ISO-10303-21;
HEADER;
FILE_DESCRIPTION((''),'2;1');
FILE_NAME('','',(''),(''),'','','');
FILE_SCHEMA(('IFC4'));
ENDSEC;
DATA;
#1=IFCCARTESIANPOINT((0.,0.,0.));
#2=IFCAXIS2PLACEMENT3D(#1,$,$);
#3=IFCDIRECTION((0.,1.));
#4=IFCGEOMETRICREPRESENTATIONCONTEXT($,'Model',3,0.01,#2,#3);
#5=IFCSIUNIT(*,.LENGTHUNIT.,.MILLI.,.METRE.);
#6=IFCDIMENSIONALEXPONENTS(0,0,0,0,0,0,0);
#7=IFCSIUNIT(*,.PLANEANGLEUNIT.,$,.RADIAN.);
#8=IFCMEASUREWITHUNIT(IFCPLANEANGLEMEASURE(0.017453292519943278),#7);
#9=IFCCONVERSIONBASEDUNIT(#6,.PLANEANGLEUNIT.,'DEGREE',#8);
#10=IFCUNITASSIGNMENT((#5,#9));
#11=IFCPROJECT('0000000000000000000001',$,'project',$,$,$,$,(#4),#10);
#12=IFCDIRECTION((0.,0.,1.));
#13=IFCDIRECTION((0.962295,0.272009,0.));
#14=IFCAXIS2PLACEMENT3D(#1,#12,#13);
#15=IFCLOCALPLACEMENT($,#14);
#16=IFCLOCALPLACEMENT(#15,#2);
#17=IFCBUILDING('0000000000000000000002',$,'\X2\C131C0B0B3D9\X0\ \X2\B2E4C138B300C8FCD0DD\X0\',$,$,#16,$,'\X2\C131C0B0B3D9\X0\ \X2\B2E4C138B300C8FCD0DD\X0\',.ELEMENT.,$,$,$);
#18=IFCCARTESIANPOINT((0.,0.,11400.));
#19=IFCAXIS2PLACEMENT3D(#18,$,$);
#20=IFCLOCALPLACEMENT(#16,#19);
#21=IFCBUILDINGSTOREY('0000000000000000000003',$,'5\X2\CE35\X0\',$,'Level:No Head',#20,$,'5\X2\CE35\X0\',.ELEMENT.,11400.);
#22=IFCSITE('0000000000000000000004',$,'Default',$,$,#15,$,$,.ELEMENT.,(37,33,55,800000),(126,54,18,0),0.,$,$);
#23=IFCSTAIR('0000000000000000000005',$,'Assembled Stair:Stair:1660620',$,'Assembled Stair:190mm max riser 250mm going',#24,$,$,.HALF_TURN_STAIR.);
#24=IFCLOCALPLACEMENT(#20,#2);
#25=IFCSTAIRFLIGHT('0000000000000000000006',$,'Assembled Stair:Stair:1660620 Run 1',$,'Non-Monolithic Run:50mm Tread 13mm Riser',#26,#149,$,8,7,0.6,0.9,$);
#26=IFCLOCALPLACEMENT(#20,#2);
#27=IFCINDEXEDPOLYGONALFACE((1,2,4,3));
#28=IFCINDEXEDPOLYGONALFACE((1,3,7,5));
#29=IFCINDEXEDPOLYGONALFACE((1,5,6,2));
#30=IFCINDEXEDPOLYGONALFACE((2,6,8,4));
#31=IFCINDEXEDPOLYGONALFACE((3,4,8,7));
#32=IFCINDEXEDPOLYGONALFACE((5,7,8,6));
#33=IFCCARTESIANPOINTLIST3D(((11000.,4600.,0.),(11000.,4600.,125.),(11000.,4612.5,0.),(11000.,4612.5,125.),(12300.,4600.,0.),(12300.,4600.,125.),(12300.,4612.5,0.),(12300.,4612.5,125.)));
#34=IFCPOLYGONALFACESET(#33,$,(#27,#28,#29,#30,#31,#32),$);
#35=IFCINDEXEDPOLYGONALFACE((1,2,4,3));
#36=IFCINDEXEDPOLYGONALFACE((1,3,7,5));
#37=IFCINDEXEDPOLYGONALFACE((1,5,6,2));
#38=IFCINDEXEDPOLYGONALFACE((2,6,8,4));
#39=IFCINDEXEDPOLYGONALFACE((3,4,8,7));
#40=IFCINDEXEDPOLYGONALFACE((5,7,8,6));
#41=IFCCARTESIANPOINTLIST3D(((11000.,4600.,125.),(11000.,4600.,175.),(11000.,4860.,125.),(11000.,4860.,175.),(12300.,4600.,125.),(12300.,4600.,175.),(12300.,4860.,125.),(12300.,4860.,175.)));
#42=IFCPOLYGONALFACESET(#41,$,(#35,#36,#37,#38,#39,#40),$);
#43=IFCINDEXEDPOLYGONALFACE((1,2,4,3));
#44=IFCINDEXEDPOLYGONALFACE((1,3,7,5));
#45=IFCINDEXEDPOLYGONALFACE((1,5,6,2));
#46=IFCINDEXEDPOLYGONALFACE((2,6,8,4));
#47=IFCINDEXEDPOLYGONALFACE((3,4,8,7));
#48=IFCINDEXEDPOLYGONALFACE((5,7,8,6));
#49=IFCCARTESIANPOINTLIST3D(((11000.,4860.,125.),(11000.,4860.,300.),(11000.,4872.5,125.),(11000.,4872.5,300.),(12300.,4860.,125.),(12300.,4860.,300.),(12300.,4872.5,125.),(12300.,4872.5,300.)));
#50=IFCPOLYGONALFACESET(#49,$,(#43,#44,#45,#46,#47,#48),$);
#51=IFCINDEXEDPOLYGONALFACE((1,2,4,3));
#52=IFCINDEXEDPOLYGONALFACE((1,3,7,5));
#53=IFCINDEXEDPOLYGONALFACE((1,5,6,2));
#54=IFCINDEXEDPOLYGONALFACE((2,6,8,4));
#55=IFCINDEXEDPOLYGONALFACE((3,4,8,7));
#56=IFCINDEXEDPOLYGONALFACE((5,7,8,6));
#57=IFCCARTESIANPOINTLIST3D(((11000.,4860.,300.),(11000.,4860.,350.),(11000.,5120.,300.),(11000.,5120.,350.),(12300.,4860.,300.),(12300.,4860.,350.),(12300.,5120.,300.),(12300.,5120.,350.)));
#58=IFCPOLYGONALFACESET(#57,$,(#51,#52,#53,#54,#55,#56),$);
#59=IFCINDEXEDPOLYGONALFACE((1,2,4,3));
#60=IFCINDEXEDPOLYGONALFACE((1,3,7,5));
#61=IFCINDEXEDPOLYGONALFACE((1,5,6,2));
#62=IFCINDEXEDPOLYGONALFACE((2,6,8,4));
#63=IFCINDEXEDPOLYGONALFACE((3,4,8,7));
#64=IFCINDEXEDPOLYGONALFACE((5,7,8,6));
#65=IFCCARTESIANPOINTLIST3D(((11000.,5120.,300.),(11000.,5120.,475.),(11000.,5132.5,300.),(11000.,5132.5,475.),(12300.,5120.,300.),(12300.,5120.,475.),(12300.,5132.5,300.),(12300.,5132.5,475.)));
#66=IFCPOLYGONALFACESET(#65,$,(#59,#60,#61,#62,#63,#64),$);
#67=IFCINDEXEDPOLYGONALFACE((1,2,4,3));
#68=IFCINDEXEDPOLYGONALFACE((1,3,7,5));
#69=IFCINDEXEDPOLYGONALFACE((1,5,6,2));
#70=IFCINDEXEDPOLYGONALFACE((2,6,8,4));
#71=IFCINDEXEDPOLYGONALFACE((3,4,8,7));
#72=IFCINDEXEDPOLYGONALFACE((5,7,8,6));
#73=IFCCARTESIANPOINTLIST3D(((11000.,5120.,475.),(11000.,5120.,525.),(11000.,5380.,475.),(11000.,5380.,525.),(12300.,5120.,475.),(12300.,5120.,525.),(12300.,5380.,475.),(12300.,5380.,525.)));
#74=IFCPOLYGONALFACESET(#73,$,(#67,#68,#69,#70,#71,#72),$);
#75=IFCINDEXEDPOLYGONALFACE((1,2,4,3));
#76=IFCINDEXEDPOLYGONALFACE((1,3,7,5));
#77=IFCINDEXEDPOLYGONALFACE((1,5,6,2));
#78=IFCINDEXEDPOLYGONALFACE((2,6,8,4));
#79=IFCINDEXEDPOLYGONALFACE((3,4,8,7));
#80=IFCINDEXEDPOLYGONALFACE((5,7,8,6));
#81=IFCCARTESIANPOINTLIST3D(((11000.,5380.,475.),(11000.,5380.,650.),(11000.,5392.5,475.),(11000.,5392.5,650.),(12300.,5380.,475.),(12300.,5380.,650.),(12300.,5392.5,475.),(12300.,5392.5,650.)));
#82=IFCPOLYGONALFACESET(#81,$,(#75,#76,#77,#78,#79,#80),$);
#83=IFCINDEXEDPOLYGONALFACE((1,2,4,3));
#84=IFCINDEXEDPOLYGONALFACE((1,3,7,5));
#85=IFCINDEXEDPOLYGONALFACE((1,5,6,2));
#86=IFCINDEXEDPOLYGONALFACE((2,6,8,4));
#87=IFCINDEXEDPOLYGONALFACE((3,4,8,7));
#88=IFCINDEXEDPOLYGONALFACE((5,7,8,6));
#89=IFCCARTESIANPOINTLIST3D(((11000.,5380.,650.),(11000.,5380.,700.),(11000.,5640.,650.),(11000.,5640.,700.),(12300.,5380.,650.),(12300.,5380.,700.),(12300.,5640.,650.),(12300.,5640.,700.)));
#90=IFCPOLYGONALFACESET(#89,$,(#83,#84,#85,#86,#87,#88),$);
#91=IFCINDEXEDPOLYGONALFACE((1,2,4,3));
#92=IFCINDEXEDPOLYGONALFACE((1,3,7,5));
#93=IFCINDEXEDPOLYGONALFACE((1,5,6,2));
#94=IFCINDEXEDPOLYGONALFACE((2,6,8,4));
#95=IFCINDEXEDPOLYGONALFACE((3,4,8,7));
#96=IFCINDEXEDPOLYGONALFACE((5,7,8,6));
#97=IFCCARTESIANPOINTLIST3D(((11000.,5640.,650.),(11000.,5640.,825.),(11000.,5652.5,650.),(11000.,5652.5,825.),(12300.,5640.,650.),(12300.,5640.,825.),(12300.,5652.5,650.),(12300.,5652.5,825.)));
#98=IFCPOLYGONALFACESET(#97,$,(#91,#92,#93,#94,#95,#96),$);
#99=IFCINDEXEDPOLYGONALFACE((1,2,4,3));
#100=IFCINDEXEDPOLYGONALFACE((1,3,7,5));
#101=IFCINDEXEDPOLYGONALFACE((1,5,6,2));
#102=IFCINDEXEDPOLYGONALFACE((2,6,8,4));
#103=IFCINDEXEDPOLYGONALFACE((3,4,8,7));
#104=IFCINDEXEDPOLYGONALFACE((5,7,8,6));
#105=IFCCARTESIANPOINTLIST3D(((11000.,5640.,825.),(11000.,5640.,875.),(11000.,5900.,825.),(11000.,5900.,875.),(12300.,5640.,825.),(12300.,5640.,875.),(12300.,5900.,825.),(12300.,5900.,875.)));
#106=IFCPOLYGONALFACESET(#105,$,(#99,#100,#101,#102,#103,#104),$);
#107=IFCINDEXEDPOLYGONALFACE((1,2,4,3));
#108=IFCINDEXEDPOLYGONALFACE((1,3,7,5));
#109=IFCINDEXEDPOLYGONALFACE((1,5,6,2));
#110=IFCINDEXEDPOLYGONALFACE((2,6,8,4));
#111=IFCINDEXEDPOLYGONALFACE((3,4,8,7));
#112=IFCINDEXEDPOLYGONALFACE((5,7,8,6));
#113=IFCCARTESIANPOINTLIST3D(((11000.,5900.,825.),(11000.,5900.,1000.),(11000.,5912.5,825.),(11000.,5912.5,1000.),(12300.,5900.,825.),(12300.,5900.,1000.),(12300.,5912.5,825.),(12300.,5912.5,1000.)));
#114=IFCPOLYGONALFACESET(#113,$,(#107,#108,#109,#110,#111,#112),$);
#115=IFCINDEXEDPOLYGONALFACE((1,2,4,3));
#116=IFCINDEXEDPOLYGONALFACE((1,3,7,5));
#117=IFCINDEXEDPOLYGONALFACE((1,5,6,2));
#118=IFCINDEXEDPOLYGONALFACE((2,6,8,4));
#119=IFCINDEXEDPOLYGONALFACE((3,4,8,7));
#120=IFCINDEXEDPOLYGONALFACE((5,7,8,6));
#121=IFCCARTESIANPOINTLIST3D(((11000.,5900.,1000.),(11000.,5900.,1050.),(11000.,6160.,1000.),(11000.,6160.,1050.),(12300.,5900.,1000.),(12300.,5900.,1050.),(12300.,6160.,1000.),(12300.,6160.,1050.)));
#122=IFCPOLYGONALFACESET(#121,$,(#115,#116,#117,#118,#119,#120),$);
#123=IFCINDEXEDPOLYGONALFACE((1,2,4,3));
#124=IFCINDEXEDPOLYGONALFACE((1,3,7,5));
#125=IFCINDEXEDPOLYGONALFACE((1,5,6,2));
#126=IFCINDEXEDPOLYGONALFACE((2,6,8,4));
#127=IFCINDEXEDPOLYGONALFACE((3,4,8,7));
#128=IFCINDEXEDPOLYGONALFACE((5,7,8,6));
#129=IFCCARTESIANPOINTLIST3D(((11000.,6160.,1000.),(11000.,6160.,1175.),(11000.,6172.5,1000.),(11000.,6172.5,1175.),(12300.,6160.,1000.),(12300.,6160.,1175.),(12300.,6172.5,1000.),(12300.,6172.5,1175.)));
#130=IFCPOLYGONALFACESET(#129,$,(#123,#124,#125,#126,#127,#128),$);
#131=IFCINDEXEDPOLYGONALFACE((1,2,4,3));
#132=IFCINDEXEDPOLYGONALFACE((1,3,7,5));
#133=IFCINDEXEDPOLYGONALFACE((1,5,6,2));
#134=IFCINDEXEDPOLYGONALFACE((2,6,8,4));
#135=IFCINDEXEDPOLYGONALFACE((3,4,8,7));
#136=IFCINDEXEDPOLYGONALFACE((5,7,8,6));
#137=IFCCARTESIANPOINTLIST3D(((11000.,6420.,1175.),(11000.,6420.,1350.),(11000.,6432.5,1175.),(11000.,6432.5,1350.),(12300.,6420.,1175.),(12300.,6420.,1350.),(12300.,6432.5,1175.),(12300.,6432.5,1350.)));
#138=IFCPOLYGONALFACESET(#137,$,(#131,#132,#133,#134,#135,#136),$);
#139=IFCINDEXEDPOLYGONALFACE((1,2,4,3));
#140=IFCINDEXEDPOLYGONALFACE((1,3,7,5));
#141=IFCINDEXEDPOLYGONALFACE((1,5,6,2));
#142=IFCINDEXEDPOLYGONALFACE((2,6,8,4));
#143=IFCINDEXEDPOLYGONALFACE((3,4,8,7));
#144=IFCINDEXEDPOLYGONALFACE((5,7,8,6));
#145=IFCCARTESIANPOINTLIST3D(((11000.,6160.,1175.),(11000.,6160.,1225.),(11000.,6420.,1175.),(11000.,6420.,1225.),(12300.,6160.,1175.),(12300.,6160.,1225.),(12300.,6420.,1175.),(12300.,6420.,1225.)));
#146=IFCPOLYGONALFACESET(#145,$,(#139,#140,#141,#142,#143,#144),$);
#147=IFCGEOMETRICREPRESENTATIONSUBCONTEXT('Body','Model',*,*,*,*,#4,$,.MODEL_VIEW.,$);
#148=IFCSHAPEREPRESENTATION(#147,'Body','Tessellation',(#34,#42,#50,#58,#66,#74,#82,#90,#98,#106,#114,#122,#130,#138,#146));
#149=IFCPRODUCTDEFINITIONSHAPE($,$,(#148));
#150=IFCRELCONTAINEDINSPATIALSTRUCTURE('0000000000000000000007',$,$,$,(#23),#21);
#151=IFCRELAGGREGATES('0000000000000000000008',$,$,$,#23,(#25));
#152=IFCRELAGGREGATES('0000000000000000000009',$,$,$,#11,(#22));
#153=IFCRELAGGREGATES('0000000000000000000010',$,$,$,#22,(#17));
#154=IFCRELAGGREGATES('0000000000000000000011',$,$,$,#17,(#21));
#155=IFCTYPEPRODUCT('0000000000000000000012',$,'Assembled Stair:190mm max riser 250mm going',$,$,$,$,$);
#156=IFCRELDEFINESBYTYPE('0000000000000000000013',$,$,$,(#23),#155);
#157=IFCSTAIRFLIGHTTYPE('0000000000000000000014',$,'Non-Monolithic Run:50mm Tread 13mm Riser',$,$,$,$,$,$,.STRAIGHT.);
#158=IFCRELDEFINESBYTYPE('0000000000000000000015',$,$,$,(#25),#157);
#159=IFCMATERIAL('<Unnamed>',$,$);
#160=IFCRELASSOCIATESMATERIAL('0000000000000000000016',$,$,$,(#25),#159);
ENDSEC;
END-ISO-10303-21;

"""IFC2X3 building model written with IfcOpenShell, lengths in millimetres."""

from ifc_helpers import new_model, entity, si_unit, converted_unit, direction, frame, frame_2d, origin, origin_2d_with_axis, place, context, subcontext, project, spatial, rectangle, extrude, material, type_object, element, aggregate, save


model = new_model("IFC2X3")

# Units and contexts
model_context = context("Model", 3, precision=0.01, world=origin(), true_north=direction((0.0, 1.0)))
body_context = subcontext(model_context, "Body", "Model", "MODEL_VIEW")
ifc_project = project(units=[si_unit("LENGTHUNIT", "METRE", prefix="MILLI"), converted_unit("PLANEANGLEUNIT", "DEGREE", entity("IfcPlaneAngleMeasure", 0.017453292519943278), si_unit("PLANEANGLEUNIT", "RADIAN"), dimensions=[0, 0, 0, 0, 0, 0, 0])], contexts=[model_context])

# Site, building, storey
site_placement = place(None, frame((0.0, 0.0, 0.0), z_axis=(0.0, 0.0, 1.0), x_axis=(0.962295, 0.272009, 0.0)))
site = spatial("IfcSite", under=ifc_project, at=site_placement, Name="Default", CompositionType="ELEMENT", RefLatitude=(37, 33, 55, 800000), RefLongitude=(126, 54, 18, 0), RefElevation=0.0)
building_placement = place(site_placement, origin())
building = spatial("IfcBuilding", under=site, at=building_placement, Name="성산동 다세대주택", LongName="성산동 다세대주택", CompositionType="ELEMENT")
storey_placement = place(building_placement, frame((0.0, 0.0, 11400.0)))
storey = spatial("IfcBuildingStorey", under=building, at=storey_placement, Name="5층", ObjectType="Level:No Head", LongName="5층", CompositionType="ELEMENT", Elevation=11400.0)

# Stair
type_product = type_object("IfcTypeProduct", Name="Assembled Stair:190mm max riser 250mm going")
stair_placement = place(storey_placement, origin())
stair = element("IfcStair", 1, at=stair_placement, inside=storey, type_object=type_product, Name="Assembled Stair:Stair:1660620", ObjectType="Assembled Stair:190mm max riser 250mm going", ShapeType="HALF_TURN_STAIR")
ifc_material_1 = material(Name="<Unnamed>")

# Stair flight
stair_flight_type = type_object("IfcStairFlightType", Name="Non-Monolithic Run:50mm Tread 13mm Riser", PredefinedType="STRAIGHT")
stair_flight_1_placement = place(stair_placement, origin())
stair_flight_1 = element("IfcStairFlight", 2, at=stair_flight_1_placement, type_object=stair_flight_type, material=ifc_material_1, Name="Assembled Stair:Stair:1660620 Run 1", ObjectType="Non-Monolithic Run:50mm Tread 13mm Riser", NumberOfRiser=8, NumberOfTreads=7, RiserHeight=0.6, TreadLength=0.9, context=body_context, shape_type="SweptSolid", body=[
    extrude(rectangle(XDim=1300.0, YDim=12.5, at=frame_2d((0.0, 0.0), x_axis=(1.0, 0.0))), frame((11650.0, 4606.2, 0.0), z_axis=(0.0, 0.0, 1.0), x_axis=(-1.0, 0.0, 0.0)), (0.0, 0.0, 1.0), 125.0),
    extrude(rectangle(XDim=260.0, YDim=1300.0, at=frame_2d((0.0, 0.0), x_axis=(1.0, 0.0))), frame((11650.0, 4730.0, 125.0), z_axis=(0.0, 0.0, 1.0), x_axis=(0.0, -1.0, 0.0)), (0.0, 0.0, 1.0), 50.0),
    extrude(rectangle(XDim=1300.0, YDim=12.5, at=frame_2d((0.0, 0.0), x_axis=(1.0, 0.0))), frame((11650.0, 4866.2, 125.0), z_axis=(0.0, 0.0, 1.0), x_axis=(-1.0, 0.0, 0.0)), (0.0, 0.0, 1.0), 175.0),
    extrude(rectangle(XDim=260.0, YDim=1300.0, at=frame_2d((0.0, 0.0), x_axis=(1.0, 0.0))), frame((11650.0, 4990.0, 300.0), z_axis=(0.0, 0.0, 1.0), x_axis=(0.0, -1.0, 0.0)), (0.0, 0.0, 1.0), 50.0),
    extrude(rectangle(XDim=1300.0, YDim=12.5, at=origin_2d_with_axis()), frame((11650.0, 5126.2, 300.0), z_axis=(0.0, 0.0, 1.0), x_axis=(-1.0, 0.0, 0.0)), (0.0, 0.0, 1.0), 175.0),
    extrude(rectangle(XDim=260.0, YDim=1300.0, at=frame_2d((0.0, 0.0), x_axis=(1.0, 0.0))), frame((11650.0, 5250.0, 475.0), z_axis=(0.0, 0.0, 1.0), x_axis=(0.0, -1.0, 0.0)), (0.0, 0.0, 1.0), 50.0),
    extrude(rectangle(XDim=1300.0, YDim=12.5, at=frame_2d((0.0, 0.0), x_axis=(1.0, 0.0))), frame((11650.0, 5386.2, 475.0), z_axis=(0.0, 0.0, 1.0), x_axis=(-1.0, 0.0, 0.0)), (0.0, 0.0, 1.0), 175.0),
    extrude(rectangle(XDim=260.0, YDim=1300.0, at=origin_2d_with_axis()), frame((11650.0, 5510.0, 650.0), z_axis=(0.0, 0.0, 1.0), x_axis=(0.0, -1.0, 0.0)), (0.0, 0.0, 1.0), 50.0),
    extrude(rectangle(XDim=1300.0, YDim=12.5, at=frame_2d((0.0, 0.0), x_axis=(1.0, 0.0))), frame((11650.0, 5646.2, 650.0), z_axis=(0.0, 0.0, 1.0), x_axis=(-1.0, 0.0, 0.0)), (0.0, 0.0, 1.0), 175.0),
    extrude(rectangle(XDim=260.0, YDim=1300.0, at=origin_2d_with_axis()), frame((11650.0, 5770.0, 825.0), z_axis=(0.0, 0.0, 1.0), x_axis=(0.0, -1.0, 0.0)), (0.0, 0.0, 1.0), 50.0),
    extrude(rectangle(XDim=1300.0, YDim=12.5, at=origin_2d_with_axis()), frame((11650.0, 5906.2, 825.0), z_axis=(0.0, 0.0, 1.0), x_axis=(-1.0, 0.0, 0.0)), (0.0, 0.0, 1.0), 175.0),
    extrude(rectangle(XDim=260.0, YDim=1300.0, at=origin_2d_with_axis()), frame((11650.0, 6030.0, 1000.0), z_axis=(0.0, 0.0, 1.0), x_axis=(0.0, -1.0, 0.0)), (0.0, 0.0, 1.0), 50.0),
    extrude(rectangle(XDim=1300.0, YDim=12.5, at=frame_2d((0.0, 0.0), x_axis=(1.0, 0.0))), frame((11650.0, 6166.2, 1000.0), z_axis=(0.0, 0.0, 1.0), x_axis=(-1.0, 0.0, 0.0)), (0.0, 0.0, 1.0), 175.0),
    extrude(rectangle(XDim=1300.0, YDim=12.5, at=frame_2d((0.0, 0.0), x_axis=(1.0, 0.0))), frame((11650.0, 6426.3, 1175.0), z_axis=(0.0, 0.0, 1.0), x_axis=(-1.0, 0.0, 0.0)), (0.0, 0.0, 1.0), 175.0),
    extrude(rectangle(XDim=260.0, YDim=1300.0, at=origin_2d_with_axis()), frame((11650.0, 6290.0, 1175.0), z_axis=(0.0, 0.0, 1.0), x_axis=(0.0, -1.0, 0.0)), (0.0, 0.0, 1.0), 50.0),
])
aggregate(stair, [stair_flight_1])

save(model, "model.ifc")
